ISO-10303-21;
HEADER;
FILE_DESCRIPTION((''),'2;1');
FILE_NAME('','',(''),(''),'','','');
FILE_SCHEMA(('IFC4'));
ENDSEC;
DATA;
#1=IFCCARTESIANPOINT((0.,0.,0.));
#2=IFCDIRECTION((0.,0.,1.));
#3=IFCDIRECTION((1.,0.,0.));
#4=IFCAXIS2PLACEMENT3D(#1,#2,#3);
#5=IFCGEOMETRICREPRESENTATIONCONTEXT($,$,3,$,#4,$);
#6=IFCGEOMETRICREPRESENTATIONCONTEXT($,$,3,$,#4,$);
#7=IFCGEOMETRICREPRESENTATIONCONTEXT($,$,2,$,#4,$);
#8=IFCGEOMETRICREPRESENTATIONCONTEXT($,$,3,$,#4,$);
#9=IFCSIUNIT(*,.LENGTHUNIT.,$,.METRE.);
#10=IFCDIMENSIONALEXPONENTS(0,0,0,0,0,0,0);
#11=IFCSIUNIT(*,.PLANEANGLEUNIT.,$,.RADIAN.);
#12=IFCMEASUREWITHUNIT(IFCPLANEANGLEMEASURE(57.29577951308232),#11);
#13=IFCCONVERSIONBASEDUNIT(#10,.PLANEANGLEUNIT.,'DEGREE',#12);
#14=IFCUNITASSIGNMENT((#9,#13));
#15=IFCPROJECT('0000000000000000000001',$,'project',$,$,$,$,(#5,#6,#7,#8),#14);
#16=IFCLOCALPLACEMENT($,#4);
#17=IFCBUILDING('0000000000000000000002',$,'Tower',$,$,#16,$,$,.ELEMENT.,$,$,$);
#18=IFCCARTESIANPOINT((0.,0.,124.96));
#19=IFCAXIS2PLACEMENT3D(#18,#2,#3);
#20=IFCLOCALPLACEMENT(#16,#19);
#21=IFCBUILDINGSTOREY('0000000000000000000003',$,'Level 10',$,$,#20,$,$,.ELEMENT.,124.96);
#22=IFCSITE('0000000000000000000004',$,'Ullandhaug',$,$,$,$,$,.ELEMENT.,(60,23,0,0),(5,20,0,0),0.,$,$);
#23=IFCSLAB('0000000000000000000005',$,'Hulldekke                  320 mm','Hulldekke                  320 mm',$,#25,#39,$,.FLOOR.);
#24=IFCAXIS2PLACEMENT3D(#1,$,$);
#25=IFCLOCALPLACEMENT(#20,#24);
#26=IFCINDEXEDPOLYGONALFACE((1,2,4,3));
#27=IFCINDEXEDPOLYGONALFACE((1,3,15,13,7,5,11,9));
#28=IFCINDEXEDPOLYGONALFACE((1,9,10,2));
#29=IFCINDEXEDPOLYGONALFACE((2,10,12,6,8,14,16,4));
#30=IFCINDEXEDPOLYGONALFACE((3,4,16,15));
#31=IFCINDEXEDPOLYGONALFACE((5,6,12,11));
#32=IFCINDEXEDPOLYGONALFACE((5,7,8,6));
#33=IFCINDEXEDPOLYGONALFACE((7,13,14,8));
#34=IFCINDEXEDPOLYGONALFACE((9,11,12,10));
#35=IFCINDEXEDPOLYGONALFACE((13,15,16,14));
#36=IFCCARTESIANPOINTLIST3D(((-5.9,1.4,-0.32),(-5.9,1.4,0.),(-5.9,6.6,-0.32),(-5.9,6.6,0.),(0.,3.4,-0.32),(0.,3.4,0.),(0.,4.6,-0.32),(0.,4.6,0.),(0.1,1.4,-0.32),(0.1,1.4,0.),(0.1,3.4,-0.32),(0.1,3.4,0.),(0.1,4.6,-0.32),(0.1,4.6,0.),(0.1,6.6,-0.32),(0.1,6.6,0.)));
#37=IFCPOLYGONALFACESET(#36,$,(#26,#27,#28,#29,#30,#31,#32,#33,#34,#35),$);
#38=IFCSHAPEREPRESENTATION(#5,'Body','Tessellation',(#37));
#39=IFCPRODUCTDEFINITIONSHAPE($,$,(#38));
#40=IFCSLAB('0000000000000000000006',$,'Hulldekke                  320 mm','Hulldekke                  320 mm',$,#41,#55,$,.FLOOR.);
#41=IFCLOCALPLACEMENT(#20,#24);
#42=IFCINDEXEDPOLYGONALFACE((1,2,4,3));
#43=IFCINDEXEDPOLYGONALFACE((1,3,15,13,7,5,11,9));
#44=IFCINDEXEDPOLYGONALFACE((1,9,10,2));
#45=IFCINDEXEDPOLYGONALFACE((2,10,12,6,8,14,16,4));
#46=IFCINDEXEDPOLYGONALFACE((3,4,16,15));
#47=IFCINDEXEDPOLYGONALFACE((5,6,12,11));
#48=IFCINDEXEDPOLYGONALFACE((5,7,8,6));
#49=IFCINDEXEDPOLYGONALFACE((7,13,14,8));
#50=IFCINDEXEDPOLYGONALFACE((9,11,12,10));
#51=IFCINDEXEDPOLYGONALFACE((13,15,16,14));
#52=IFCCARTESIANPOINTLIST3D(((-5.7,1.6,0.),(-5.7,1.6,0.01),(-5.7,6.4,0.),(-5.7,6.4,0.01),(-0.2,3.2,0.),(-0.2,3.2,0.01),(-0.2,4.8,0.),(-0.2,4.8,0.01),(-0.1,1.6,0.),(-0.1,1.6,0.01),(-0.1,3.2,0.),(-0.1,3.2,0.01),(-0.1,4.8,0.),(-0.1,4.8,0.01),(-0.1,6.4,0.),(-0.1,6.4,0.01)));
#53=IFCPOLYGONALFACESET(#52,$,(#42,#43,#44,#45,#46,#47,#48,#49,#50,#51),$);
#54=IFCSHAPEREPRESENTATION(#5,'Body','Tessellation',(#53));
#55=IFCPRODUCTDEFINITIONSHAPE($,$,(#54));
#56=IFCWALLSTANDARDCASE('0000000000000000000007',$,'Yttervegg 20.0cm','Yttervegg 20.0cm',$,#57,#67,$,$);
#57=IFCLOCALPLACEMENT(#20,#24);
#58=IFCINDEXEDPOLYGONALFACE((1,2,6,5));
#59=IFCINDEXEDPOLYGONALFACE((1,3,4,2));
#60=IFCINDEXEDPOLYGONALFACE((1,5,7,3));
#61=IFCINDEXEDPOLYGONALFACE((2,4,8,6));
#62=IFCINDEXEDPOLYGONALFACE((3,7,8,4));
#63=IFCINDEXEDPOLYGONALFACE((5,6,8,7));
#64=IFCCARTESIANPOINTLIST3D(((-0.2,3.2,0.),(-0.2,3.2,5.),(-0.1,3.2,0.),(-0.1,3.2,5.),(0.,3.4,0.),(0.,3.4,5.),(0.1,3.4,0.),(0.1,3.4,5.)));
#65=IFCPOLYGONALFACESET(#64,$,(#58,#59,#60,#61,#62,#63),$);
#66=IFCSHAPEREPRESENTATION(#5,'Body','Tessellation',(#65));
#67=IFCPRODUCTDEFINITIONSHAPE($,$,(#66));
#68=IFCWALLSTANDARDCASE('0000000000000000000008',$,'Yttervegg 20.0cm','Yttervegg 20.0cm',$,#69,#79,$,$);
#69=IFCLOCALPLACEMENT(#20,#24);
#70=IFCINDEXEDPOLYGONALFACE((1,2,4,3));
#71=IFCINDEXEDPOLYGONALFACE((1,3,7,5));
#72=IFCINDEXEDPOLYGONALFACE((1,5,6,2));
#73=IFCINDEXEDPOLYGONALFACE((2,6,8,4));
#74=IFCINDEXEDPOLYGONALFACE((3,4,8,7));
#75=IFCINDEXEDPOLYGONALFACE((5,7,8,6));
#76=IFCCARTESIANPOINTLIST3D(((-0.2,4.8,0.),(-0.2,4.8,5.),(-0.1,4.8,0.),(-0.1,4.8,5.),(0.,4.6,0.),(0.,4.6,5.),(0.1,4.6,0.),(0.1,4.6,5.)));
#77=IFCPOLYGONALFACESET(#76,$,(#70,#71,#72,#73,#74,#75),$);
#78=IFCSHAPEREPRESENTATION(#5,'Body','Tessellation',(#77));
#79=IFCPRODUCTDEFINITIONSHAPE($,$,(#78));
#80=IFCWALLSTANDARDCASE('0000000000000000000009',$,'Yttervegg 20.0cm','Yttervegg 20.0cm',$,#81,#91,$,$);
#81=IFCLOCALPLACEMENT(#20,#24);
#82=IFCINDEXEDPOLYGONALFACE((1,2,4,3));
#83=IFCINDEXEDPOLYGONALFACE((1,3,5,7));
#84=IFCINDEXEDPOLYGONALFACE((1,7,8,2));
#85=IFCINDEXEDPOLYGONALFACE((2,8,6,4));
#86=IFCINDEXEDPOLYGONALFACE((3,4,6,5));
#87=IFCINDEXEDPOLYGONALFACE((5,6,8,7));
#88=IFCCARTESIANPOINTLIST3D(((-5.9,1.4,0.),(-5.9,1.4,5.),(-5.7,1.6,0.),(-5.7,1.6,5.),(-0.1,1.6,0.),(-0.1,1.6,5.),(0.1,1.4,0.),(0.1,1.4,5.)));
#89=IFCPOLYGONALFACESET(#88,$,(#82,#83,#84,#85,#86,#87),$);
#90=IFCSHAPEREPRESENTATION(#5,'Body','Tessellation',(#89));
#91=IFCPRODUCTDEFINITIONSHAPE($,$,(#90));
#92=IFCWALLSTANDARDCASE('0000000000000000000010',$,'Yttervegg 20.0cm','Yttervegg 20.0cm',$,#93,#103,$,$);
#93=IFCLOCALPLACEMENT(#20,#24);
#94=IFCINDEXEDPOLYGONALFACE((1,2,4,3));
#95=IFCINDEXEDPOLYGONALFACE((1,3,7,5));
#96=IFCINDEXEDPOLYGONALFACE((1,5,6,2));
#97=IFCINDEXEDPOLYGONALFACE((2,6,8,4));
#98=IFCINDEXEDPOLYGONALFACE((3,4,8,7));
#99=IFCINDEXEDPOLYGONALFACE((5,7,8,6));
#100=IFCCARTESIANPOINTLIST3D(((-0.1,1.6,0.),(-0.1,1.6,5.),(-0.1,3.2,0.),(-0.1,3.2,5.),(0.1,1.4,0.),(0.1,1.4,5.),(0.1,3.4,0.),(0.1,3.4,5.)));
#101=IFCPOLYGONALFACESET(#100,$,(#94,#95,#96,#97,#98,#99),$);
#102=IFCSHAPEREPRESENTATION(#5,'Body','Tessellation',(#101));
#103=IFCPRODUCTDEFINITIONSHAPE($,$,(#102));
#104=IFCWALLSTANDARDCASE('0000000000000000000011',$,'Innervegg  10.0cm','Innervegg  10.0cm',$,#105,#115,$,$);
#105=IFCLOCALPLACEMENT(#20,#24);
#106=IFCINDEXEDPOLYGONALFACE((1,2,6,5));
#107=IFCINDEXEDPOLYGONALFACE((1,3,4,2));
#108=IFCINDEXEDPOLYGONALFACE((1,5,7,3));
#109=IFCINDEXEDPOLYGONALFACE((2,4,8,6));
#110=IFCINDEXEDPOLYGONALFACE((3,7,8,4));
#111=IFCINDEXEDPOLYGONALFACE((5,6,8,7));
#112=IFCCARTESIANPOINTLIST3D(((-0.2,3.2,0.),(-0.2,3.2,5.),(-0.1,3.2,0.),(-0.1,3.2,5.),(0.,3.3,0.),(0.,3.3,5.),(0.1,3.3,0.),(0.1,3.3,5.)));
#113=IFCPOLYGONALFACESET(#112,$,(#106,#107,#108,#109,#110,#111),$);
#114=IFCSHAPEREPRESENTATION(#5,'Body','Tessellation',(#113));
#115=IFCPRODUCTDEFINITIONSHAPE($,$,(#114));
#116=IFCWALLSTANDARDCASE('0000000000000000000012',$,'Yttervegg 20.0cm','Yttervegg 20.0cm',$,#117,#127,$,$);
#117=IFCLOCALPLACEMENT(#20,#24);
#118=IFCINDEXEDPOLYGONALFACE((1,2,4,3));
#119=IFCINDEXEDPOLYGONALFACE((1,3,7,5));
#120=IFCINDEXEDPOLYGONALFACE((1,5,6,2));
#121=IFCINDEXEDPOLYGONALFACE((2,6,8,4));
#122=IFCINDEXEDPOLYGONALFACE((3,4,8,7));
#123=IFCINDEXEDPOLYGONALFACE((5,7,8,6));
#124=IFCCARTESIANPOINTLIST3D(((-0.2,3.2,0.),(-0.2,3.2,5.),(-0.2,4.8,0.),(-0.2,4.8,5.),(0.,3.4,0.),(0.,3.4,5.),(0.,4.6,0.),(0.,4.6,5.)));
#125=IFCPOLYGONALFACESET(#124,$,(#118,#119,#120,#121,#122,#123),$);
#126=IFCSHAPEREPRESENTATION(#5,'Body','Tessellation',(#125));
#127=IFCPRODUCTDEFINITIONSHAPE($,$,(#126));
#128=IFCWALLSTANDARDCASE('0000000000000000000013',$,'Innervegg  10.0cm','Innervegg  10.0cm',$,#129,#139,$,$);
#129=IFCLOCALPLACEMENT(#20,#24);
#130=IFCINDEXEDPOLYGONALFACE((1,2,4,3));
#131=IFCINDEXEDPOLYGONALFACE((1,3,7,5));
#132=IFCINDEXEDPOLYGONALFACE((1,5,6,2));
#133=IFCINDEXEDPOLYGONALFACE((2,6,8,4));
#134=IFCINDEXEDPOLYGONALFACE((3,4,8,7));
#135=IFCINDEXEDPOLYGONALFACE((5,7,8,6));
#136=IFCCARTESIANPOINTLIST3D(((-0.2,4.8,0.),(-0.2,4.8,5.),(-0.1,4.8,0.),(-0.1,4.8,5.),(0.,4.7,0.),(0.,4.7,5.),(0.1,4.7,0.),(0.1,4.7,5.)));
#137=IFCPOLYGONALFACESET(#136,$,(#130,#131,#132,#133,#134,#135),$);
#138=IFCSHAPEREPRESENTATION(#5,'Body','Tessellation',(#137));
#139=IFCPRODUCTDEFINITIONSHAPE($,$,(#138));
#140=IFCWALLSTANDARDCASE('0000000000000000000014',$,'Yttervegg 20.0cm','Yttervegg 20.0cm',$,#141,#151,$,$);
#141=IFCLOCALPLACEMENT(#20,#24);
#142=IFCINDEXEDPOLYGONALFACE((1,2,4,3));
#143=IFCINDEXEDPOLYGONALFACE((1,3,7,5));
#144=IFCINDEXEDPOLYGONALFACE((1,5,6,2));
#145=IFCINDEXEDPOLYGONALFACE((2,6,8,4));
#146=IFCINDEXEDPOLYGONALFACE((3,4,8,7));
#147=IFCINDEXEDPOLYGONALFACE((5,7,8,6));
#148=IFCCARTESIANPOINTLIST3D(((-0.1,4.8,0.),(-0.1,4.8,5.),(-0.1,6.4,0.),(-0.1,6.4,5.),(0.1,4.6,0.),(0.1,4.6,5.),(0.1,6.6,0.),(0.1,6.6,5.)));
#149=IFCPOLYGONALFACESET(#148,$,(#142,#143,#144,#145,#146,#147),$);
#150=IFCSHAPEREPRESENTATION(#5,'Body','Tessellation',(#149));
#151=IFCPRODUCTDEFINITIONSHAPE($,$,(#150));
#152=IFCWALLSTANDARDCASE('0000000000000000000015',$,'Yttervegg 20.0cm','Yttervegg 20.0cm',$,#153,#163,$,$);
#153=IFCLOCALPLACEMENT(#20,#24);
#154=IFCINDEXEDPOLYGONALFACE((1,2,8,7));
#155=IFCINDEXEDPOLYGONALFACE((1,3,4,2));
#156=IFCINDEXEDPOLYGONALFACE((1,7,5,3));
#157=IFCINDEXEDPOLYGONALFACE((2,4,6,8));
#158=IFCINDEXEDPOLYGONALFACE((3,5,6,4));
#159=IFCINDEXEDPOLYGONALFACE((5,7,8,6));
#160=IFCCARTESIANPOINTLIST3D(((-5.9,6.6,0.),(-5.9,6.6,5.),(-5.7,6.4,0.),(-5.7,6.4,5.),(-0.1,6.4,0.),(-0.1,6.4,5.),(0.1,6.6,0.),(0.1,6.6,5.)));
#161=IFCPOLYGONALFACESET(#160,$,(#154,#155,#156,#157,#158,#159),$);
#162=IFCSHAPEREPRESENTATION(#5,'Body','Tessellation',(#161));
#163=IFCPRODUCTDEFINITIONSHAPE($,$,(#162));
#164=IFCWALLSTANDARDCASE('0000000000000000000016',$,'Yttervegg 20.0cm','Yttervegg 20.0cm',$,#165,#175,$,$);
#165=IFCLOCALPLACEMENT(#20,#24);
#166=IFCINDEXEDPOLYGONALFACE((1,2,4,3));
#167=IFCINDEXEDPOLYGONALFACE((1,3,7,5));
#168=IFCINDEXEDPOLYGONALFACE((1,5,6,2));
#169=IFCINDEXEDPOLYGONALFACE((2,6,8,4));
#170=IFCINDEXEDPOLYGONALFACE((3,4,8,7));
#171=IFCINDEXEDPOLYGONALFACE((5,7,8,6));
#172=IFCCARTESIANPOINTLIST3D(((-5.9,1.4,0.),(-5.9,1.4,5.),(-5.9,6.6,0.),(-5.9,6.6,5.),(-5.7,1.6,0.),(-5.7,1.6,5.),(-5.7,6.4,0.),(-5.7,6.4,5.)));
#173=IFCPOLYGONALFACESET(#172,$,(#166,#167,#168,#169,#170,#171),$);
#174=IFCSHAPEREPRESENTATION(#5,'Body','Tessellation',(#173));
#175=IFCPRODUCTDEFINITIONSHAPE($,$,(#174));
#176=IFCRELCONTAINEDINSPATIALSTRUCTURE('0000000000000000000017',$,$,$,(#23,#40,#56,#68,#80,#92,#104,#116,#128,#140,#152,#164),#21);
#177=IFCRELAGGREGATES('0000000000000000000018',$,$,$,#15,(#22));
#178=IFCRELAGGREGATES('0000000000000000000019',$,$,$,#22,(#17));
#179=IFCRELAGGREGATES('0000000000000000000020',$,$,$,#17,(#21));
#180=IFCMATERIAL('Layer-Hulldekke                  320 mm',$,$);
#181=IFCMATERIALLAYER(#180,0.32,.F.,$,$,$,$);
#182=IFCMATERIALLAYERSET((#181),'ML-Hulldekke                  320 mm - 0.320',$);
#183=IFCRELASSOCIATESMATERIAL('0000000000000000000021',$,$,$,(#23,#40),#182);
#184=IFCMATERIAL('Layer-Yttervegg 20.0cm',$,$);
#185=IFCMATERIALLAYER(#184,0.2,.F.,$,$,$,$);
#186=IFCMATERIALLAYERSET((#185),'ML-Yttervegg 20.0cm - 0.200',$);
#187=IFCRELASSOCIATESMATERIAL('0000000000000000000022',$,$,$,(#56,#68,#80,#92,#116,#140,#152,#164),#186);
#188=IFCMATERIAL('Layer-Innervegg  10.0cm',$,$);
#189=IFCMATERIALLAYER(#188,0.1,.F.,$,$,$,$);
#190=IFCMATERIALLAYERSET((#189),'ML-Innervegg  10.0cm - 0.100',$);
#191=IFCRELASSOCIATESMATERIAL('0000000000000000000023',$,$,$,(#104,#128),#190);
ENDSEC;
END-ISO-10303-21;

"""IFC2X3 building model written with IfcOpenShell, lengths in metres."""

from ifc_helpers import new_model, entity, si_unit, converted_unit, frame, origin_with_axes, place, context, project, spatial, polyline, outline, extrude, material, layer, layer_set, layer_usage, element, save


model = new_model("IFC2X3")

# Units and contexts
context_of_model_1 = context(None, 3, world=origin_with_axes())
context_of_model_2 = context(None, 3, world=origin_with_axes())
context_of_model_3 = context(None, 2, world=origin_with_axes())
context_of_model_4 = context(None, 3, world=origin_with_axes())
ifc_project = project(units=[si_unit("LENGTHUNIT", "METRE"), converted_unit("PLANEANGLEUNIT", "DEGREE", entity("IfcPlaneAngleMeasure", 57.29577951308232), si_unit("PLANEANGLEUNIT", "RADIAN"), dimensions=[0, 0, 0, 0, 0, 0, 0])], contexts=[context_of_model_1, context_of_model_2, context_of_model_3, context_of_model_4])

# Site, building, storey
site = spatial("IfcSite", under=ifc_project, Name="Ullandhaug", CompositionType="ELEMENT", RefLatitude=(60, 23, 0, 0), RefLongitude=(5, 20, 0, 0), RefElevation=0.0)
building_placement = place(None, origin_with_axes())
building = spatial("IfcBuilding", under=site, at=building_placement, Name="Tower", CompositionType="ELEMENT")
storey_placement = place(building_placement, frame((0.0, 0.0, 124.96), z_axis=(0.0, 0.0, 1.0), x_axis=(1.0, 0.0, 0.0)))
storey = spatial("IfcBuildingStorey", under=building, at=storey_placement, Name="Level 10", CompositionType="ELEMENT", Elevation=124.96)

# Slabs
ifc_material_1 = material(Name="Layer-Hulldekke                  320 mm")
ifc_layer_1 = layer(ifc_material_1, 0.32, ventilated=False)
ifc_layer_set_1 = layer_set([ifc_layer_1], Name="ML-Hulldekke                  320 mm - 0.320")
ifc_layer_usage_1 = layer_usage(ifc_layer_set_1, "AXIS2", "POSITIVE", 0.0)
slab_1_placement = place(storey_placement, frame((-5.9, 1.4, 0.0), z_axis=(0.0, 0.0, 1.0), x_axis=(1.0, 0.0, 0.0)))
element("IfcSlab", 1, at=slab_1_placement, inside=storey, material=ifc_layer_usage_1, Name="Hulldekke                  320 mm", Description="Hulldekke                  320 mm", PredefinedType="FLOOR", context=context_of_model_1, shape_type="SweptSolid", body=[
    extrude(outline(polyline([(0.0, 0.0), (6.0, 0.0), (6.0, 2.0), (5.9, 2.0), (5.9, 3.2), (6.0, 3.2), (6.0, 5.2), (0.0, 5.2), (0.0, 0.0)])), origin_with_axes(), (0.0, 0.0, -1.0), 0.32),
])
slab_2_placement = place(storey_placement, frame((-5.7, 1.6, 0.0), z_axis=(0.0, 0.0, 1.0), x_axis=(1.0, 0.0, 0.0)))
element("IfcSlab", 2, at=slab_2_placement, inside=storey, material=ifc_layer_usage_1, Name="Hulldekke                  320 mm", Description="Hulldekke                  320 mm", PredefinedType="FLOOR", context=context_of_model_1, shape_type="SweptSolid", body=[
    extrude(outline(polyline([(0.0, 0.0), (5.6, 0.0), (5.6, 1.6), (5.5, 1.6), (5.5, 3.2), (5.6, 3.2), (5.6, 4.8), (0.0, 4.8), (0.0, 0.0)])), origin_with_axes(), (0.0, 0.0, 1.0), 0.01),
])

# Walls
ifc_material_2 = material(Name="Layer-Yttervegg 20.0cm")
ifc_layer_2 = layer(ifc_material_2, 0.2, ventilated=False)
ifc_layer_set_2 = layer_set([ifc_layer_2], Name="ML-Yttervegg 20.0cm - 0.200")
ifc_layer_usage_2 = layer_usage(ifc_layer_set_2, "AXIS2", "POSITIVE", 0.0)
wall_1_placement = place(storey_placement, frame((0.1, 3.4, 0.0), z_axis=(0.0, 0.0, 1.0), x_axis=(-1.0, 0.0, 0.0)))
element("IfcWallStandardCase", 3, at=wall_1_placement, inside=storey, material=ifc_layer_usage_2, Name="Yttervegg 20.0cm", Description="Yttervegg 20.0cm", context=context_of_model_1, shape_type="SweptSolid", body=[
    extrude(outline(polyline([(0.0, 0.0), (0.1, 0.0), (0.3, 0.2), (0.2, 0.2), (0.0, 0.0)])), frame((0.0, 0.0, 0.0), z_axis=(0.0, 0.0, 1.0), x_axis=(1.0, 0.0, 0.0)), (0.0, 0.0, 1.0), 5.0),
])
wall_2_placement = place(storey_placement, frame((0.0, 4.6, 0.0), z_axis=(0.0, 0.0, 1.0), x_axis=(1.0, 0.0, 0.0)))
element("IfcWallStandardCase", 4, at=wall_2_placement, inside=storey, material=ifc_layer_usage_2, Name="Yttervegg 20.0cm", Description="Yttervegg 20.0cm", context=context_of_model_1, shape_type="SweptSolid", body=[
    extrude(outline(polyline([(0.0, 0.0), (0.1, 0.0), (-0.1, 0.2), (-0.2, 0.2), (0.0, 0.0)])), origin_with_axes(), (0.0, 0.0, 1.0), 5.0),
])
wall_3_placement = place(storey_placement, frame((-5.9, 1.4, 0.0), z_axis=(0.0, 0.0, 1.0), x_axis=(1.0, 0.0, 0.0)))
element("IfcWallStandardCase", 5, at=wall_3_placement, inside=storey, material=ifc_layer_usage_2, Name="Yttervegg 20.0cm", Description="Yttervegg 20.0cm", context=context_of_model_1, shape_type="SweptSolid", body=[
    extrude(outline(polyline([(0.0, 0.0), (6.0, 0.0), (5.8, 0.2), (0.2, 0.2), (0.0, 0.0)])), origin_with_axes(), (0.0, 0.0, 1.0), 5.0),
])
wall_4_placement = place(storey_placement, frame((0.1, 1.4, 0.0), z_axis=(0.0, 0.0, 1.0), x_axis=(0.0, 1.0, 0.0)))
element("IfcWallStandardCase", 6, at=wall_4_placement, inside=storey, material=ifc_layer_usage_2, Name="Yttervegg 20.0cm", Description="Yttervegg 20.0cm", context=context_of_model_1, shape_type="SweptSolid", body=[
    extrude(outline(polyline([(0.0, 0.0), (2.0, 0.0), (1.8, 0.2), (0.2, 0.2), (0.0, 0.0)])), frame((0.0, 0.0, 0.0), z_axis=(0.0, 0.0, 1.0), x_axis=(1.0, 0.0, 0.0)), (0.0, 0.0, 1.0), 5.0),
])
ifc_material_3 = material(Name="Layer-Innervegg  10.0cm")
ifc_layer_3 = layer(ifc_material_3, 0.1, ventilated=False)
ifc_layer_set_3 = layer_set([ifc_layer_3], Name="ML-Innervegg  10.0cm - 0.100")
ifc_layer_usage_3 = layer_usage(ifc_layer_set_3, "AXIS2", "POSITIVE", 0.0)
wall_5_placement = place(storey_placement, frame((0.1, 3.3, 0.0), z_axis=(0.0, 0.0, 1.0), x_axis=(-1.0, 0.0, 0.0)))
element("IfcWallStandardCase", 7, at=wall_5_placement, inside=storey, material=ifc_layer_usage_3, Name="Innervegg  10.0cm", Description="Innervegg  10.0cm", context=context_of_model_1, shape_type="SweptSolid", body=[
    extrude(outline(polyline([(0.0, 0.0), (0.1, 0.0), (0.3, 0.1), (0.2, 0.1), (0.0, 0.0)])), frame((0.0, 0.0, 0.0), z_axis=(0.0, 0.0, 1.0), x_axis=(1.0, 0.0, 0.0)), (0.0, 0.0, 1.0), 5.0),
])
wall_6_placement = place(storey_placement, frame((0.0, 3.4, 0.0), z_axis=(0.0, 0.0, 1.0), x_axis=(0.0, 1.0, 0.0)))
element("IfcWallStandardCase", 8, at=wall_6_placement, inside=storey, material=ifc_layer_usage_2, Name="Yttervegg 20.0cm", Description="Yttervegg 20.0cm", context=context_of_model_1, shape_type="SweptSolid", body=[
    extrude(outline(polyline([(0.0, 0.0), (1.2, 0.0), (1.4, 0.2), (-0.2, 0.2), (0.0, 0.0)])), frame((0.0, 0.0, 0.0), z_axis=(0.0, 0.0, 1.0), x_axis=(1.0, 0.0, 0.0)), (0.0, 0.0, 1.0), 5.0),
])
wall_7_placement = place(storey_placement, frame((0.0, 4.7, 0.0), z_axis=(0.0, 0.0, 1.0), x_axis=(1.0, 0.0, 0.0)))
element("IfcWallStandardCase", 9, at=wall_7_placement, inside=storey, material=ifc_layer_usage_3, Name="Innervegg  10.0cm", Description="Innervegg  10.0cm", context=context_of_model_1, shape_type="SweptSolid", body=[
    extrude(outline(polyline([(0.0, 0.0), (0.1, 0.0), (-0.1, 0.1), (-0.2, 0.1), (0.0, 0.0)])), origin_with_axes(), (0.0, 0.0, 1.0), 5.0),
])
wall_8_placement = place(storey_placement, frame((0.1, 4.6, 0.0), z_axis=(0.0, 0.0, 1.0), x_axis=(0.0, 1.0, 0.0)))
element("IfcWallStandardCase", 10, at=wall_8_placement, inside=storey, material=ifc_layer_usage_2, Name="Yttervegg 20.0cm", Description="Yttervegg 20.0cm", context=context_of_model_1, shape_type="SweptSolid", body=[
    extrude(outline(polyline([(0.0, 0.0), (2.0, 0.0), (1.8, 0.2), (0.2, 0.2), (0.0, 0.0)])), frame((0.0, 0.0, 0.0), z_axis=(0.0, 0.0, 1.0), x_axis=(1.0, 0.0, 0.0)), (0.0, 0.0, 1.0), 5.0),
])
wall_9_placement = place(storey_placement, frame((0.1, 6.6, 0.0), z_axis=(0.0, 0.0, 1.0), x_axis=(-1.0, 0.0, 0.0)))
element("IfcWallStandardCase", 11, at=wall_9_placement, inside=storey, material=ifc_layer_usage_2, Name="Yttervegg 20.0cm", Description="Yttervegg 20.0cm", context=context_of_model_1, shape_type="SweptSolid", body=[
    extrude(outline(polyline([(0.0, 0.0), (6.0, 0.0), (5.8, 0.2), (0.2, 0.2), (0.0, 0.0)])), frame((0.0, 0.0, 0.0), z_axis=(0.0, 0.0, 1.0), x_axis=(1.0, 0.0, 0.0)), (0.0, 0.0, 1.0), 5.0),
])
wall_10_placement = place(storey_placement, frame((-5.9, 6.6, 0.0), z_axis=(0.0, 0.0, 1.0), x_axis=(0.0, -1.0, 0.0)))
element("IfcWallStandardCase", 12, at=wall_10_placement, inside=storey, material=ifc_layer_usage_2, Name="Yttervegg 20.0cm", Description="Yttervegg 20.0cm", context=context_of_model_1, shape_type="SweptSolid", body=[
    extrude(outline(polyline([(0.0, 0.0), (5.2, 0.0), (5.0, 0.2), (0.2, 0.2), (0.0, 0.0)])), frame((0.0, 0.0, 0.0), z_axis=(0.0, 0.0, 1.0), x_axis=(1.0, 0.0, 0.0)), (0.0, 0.0, 1.0), 5.0),
])

save(model, "model.ifc")
